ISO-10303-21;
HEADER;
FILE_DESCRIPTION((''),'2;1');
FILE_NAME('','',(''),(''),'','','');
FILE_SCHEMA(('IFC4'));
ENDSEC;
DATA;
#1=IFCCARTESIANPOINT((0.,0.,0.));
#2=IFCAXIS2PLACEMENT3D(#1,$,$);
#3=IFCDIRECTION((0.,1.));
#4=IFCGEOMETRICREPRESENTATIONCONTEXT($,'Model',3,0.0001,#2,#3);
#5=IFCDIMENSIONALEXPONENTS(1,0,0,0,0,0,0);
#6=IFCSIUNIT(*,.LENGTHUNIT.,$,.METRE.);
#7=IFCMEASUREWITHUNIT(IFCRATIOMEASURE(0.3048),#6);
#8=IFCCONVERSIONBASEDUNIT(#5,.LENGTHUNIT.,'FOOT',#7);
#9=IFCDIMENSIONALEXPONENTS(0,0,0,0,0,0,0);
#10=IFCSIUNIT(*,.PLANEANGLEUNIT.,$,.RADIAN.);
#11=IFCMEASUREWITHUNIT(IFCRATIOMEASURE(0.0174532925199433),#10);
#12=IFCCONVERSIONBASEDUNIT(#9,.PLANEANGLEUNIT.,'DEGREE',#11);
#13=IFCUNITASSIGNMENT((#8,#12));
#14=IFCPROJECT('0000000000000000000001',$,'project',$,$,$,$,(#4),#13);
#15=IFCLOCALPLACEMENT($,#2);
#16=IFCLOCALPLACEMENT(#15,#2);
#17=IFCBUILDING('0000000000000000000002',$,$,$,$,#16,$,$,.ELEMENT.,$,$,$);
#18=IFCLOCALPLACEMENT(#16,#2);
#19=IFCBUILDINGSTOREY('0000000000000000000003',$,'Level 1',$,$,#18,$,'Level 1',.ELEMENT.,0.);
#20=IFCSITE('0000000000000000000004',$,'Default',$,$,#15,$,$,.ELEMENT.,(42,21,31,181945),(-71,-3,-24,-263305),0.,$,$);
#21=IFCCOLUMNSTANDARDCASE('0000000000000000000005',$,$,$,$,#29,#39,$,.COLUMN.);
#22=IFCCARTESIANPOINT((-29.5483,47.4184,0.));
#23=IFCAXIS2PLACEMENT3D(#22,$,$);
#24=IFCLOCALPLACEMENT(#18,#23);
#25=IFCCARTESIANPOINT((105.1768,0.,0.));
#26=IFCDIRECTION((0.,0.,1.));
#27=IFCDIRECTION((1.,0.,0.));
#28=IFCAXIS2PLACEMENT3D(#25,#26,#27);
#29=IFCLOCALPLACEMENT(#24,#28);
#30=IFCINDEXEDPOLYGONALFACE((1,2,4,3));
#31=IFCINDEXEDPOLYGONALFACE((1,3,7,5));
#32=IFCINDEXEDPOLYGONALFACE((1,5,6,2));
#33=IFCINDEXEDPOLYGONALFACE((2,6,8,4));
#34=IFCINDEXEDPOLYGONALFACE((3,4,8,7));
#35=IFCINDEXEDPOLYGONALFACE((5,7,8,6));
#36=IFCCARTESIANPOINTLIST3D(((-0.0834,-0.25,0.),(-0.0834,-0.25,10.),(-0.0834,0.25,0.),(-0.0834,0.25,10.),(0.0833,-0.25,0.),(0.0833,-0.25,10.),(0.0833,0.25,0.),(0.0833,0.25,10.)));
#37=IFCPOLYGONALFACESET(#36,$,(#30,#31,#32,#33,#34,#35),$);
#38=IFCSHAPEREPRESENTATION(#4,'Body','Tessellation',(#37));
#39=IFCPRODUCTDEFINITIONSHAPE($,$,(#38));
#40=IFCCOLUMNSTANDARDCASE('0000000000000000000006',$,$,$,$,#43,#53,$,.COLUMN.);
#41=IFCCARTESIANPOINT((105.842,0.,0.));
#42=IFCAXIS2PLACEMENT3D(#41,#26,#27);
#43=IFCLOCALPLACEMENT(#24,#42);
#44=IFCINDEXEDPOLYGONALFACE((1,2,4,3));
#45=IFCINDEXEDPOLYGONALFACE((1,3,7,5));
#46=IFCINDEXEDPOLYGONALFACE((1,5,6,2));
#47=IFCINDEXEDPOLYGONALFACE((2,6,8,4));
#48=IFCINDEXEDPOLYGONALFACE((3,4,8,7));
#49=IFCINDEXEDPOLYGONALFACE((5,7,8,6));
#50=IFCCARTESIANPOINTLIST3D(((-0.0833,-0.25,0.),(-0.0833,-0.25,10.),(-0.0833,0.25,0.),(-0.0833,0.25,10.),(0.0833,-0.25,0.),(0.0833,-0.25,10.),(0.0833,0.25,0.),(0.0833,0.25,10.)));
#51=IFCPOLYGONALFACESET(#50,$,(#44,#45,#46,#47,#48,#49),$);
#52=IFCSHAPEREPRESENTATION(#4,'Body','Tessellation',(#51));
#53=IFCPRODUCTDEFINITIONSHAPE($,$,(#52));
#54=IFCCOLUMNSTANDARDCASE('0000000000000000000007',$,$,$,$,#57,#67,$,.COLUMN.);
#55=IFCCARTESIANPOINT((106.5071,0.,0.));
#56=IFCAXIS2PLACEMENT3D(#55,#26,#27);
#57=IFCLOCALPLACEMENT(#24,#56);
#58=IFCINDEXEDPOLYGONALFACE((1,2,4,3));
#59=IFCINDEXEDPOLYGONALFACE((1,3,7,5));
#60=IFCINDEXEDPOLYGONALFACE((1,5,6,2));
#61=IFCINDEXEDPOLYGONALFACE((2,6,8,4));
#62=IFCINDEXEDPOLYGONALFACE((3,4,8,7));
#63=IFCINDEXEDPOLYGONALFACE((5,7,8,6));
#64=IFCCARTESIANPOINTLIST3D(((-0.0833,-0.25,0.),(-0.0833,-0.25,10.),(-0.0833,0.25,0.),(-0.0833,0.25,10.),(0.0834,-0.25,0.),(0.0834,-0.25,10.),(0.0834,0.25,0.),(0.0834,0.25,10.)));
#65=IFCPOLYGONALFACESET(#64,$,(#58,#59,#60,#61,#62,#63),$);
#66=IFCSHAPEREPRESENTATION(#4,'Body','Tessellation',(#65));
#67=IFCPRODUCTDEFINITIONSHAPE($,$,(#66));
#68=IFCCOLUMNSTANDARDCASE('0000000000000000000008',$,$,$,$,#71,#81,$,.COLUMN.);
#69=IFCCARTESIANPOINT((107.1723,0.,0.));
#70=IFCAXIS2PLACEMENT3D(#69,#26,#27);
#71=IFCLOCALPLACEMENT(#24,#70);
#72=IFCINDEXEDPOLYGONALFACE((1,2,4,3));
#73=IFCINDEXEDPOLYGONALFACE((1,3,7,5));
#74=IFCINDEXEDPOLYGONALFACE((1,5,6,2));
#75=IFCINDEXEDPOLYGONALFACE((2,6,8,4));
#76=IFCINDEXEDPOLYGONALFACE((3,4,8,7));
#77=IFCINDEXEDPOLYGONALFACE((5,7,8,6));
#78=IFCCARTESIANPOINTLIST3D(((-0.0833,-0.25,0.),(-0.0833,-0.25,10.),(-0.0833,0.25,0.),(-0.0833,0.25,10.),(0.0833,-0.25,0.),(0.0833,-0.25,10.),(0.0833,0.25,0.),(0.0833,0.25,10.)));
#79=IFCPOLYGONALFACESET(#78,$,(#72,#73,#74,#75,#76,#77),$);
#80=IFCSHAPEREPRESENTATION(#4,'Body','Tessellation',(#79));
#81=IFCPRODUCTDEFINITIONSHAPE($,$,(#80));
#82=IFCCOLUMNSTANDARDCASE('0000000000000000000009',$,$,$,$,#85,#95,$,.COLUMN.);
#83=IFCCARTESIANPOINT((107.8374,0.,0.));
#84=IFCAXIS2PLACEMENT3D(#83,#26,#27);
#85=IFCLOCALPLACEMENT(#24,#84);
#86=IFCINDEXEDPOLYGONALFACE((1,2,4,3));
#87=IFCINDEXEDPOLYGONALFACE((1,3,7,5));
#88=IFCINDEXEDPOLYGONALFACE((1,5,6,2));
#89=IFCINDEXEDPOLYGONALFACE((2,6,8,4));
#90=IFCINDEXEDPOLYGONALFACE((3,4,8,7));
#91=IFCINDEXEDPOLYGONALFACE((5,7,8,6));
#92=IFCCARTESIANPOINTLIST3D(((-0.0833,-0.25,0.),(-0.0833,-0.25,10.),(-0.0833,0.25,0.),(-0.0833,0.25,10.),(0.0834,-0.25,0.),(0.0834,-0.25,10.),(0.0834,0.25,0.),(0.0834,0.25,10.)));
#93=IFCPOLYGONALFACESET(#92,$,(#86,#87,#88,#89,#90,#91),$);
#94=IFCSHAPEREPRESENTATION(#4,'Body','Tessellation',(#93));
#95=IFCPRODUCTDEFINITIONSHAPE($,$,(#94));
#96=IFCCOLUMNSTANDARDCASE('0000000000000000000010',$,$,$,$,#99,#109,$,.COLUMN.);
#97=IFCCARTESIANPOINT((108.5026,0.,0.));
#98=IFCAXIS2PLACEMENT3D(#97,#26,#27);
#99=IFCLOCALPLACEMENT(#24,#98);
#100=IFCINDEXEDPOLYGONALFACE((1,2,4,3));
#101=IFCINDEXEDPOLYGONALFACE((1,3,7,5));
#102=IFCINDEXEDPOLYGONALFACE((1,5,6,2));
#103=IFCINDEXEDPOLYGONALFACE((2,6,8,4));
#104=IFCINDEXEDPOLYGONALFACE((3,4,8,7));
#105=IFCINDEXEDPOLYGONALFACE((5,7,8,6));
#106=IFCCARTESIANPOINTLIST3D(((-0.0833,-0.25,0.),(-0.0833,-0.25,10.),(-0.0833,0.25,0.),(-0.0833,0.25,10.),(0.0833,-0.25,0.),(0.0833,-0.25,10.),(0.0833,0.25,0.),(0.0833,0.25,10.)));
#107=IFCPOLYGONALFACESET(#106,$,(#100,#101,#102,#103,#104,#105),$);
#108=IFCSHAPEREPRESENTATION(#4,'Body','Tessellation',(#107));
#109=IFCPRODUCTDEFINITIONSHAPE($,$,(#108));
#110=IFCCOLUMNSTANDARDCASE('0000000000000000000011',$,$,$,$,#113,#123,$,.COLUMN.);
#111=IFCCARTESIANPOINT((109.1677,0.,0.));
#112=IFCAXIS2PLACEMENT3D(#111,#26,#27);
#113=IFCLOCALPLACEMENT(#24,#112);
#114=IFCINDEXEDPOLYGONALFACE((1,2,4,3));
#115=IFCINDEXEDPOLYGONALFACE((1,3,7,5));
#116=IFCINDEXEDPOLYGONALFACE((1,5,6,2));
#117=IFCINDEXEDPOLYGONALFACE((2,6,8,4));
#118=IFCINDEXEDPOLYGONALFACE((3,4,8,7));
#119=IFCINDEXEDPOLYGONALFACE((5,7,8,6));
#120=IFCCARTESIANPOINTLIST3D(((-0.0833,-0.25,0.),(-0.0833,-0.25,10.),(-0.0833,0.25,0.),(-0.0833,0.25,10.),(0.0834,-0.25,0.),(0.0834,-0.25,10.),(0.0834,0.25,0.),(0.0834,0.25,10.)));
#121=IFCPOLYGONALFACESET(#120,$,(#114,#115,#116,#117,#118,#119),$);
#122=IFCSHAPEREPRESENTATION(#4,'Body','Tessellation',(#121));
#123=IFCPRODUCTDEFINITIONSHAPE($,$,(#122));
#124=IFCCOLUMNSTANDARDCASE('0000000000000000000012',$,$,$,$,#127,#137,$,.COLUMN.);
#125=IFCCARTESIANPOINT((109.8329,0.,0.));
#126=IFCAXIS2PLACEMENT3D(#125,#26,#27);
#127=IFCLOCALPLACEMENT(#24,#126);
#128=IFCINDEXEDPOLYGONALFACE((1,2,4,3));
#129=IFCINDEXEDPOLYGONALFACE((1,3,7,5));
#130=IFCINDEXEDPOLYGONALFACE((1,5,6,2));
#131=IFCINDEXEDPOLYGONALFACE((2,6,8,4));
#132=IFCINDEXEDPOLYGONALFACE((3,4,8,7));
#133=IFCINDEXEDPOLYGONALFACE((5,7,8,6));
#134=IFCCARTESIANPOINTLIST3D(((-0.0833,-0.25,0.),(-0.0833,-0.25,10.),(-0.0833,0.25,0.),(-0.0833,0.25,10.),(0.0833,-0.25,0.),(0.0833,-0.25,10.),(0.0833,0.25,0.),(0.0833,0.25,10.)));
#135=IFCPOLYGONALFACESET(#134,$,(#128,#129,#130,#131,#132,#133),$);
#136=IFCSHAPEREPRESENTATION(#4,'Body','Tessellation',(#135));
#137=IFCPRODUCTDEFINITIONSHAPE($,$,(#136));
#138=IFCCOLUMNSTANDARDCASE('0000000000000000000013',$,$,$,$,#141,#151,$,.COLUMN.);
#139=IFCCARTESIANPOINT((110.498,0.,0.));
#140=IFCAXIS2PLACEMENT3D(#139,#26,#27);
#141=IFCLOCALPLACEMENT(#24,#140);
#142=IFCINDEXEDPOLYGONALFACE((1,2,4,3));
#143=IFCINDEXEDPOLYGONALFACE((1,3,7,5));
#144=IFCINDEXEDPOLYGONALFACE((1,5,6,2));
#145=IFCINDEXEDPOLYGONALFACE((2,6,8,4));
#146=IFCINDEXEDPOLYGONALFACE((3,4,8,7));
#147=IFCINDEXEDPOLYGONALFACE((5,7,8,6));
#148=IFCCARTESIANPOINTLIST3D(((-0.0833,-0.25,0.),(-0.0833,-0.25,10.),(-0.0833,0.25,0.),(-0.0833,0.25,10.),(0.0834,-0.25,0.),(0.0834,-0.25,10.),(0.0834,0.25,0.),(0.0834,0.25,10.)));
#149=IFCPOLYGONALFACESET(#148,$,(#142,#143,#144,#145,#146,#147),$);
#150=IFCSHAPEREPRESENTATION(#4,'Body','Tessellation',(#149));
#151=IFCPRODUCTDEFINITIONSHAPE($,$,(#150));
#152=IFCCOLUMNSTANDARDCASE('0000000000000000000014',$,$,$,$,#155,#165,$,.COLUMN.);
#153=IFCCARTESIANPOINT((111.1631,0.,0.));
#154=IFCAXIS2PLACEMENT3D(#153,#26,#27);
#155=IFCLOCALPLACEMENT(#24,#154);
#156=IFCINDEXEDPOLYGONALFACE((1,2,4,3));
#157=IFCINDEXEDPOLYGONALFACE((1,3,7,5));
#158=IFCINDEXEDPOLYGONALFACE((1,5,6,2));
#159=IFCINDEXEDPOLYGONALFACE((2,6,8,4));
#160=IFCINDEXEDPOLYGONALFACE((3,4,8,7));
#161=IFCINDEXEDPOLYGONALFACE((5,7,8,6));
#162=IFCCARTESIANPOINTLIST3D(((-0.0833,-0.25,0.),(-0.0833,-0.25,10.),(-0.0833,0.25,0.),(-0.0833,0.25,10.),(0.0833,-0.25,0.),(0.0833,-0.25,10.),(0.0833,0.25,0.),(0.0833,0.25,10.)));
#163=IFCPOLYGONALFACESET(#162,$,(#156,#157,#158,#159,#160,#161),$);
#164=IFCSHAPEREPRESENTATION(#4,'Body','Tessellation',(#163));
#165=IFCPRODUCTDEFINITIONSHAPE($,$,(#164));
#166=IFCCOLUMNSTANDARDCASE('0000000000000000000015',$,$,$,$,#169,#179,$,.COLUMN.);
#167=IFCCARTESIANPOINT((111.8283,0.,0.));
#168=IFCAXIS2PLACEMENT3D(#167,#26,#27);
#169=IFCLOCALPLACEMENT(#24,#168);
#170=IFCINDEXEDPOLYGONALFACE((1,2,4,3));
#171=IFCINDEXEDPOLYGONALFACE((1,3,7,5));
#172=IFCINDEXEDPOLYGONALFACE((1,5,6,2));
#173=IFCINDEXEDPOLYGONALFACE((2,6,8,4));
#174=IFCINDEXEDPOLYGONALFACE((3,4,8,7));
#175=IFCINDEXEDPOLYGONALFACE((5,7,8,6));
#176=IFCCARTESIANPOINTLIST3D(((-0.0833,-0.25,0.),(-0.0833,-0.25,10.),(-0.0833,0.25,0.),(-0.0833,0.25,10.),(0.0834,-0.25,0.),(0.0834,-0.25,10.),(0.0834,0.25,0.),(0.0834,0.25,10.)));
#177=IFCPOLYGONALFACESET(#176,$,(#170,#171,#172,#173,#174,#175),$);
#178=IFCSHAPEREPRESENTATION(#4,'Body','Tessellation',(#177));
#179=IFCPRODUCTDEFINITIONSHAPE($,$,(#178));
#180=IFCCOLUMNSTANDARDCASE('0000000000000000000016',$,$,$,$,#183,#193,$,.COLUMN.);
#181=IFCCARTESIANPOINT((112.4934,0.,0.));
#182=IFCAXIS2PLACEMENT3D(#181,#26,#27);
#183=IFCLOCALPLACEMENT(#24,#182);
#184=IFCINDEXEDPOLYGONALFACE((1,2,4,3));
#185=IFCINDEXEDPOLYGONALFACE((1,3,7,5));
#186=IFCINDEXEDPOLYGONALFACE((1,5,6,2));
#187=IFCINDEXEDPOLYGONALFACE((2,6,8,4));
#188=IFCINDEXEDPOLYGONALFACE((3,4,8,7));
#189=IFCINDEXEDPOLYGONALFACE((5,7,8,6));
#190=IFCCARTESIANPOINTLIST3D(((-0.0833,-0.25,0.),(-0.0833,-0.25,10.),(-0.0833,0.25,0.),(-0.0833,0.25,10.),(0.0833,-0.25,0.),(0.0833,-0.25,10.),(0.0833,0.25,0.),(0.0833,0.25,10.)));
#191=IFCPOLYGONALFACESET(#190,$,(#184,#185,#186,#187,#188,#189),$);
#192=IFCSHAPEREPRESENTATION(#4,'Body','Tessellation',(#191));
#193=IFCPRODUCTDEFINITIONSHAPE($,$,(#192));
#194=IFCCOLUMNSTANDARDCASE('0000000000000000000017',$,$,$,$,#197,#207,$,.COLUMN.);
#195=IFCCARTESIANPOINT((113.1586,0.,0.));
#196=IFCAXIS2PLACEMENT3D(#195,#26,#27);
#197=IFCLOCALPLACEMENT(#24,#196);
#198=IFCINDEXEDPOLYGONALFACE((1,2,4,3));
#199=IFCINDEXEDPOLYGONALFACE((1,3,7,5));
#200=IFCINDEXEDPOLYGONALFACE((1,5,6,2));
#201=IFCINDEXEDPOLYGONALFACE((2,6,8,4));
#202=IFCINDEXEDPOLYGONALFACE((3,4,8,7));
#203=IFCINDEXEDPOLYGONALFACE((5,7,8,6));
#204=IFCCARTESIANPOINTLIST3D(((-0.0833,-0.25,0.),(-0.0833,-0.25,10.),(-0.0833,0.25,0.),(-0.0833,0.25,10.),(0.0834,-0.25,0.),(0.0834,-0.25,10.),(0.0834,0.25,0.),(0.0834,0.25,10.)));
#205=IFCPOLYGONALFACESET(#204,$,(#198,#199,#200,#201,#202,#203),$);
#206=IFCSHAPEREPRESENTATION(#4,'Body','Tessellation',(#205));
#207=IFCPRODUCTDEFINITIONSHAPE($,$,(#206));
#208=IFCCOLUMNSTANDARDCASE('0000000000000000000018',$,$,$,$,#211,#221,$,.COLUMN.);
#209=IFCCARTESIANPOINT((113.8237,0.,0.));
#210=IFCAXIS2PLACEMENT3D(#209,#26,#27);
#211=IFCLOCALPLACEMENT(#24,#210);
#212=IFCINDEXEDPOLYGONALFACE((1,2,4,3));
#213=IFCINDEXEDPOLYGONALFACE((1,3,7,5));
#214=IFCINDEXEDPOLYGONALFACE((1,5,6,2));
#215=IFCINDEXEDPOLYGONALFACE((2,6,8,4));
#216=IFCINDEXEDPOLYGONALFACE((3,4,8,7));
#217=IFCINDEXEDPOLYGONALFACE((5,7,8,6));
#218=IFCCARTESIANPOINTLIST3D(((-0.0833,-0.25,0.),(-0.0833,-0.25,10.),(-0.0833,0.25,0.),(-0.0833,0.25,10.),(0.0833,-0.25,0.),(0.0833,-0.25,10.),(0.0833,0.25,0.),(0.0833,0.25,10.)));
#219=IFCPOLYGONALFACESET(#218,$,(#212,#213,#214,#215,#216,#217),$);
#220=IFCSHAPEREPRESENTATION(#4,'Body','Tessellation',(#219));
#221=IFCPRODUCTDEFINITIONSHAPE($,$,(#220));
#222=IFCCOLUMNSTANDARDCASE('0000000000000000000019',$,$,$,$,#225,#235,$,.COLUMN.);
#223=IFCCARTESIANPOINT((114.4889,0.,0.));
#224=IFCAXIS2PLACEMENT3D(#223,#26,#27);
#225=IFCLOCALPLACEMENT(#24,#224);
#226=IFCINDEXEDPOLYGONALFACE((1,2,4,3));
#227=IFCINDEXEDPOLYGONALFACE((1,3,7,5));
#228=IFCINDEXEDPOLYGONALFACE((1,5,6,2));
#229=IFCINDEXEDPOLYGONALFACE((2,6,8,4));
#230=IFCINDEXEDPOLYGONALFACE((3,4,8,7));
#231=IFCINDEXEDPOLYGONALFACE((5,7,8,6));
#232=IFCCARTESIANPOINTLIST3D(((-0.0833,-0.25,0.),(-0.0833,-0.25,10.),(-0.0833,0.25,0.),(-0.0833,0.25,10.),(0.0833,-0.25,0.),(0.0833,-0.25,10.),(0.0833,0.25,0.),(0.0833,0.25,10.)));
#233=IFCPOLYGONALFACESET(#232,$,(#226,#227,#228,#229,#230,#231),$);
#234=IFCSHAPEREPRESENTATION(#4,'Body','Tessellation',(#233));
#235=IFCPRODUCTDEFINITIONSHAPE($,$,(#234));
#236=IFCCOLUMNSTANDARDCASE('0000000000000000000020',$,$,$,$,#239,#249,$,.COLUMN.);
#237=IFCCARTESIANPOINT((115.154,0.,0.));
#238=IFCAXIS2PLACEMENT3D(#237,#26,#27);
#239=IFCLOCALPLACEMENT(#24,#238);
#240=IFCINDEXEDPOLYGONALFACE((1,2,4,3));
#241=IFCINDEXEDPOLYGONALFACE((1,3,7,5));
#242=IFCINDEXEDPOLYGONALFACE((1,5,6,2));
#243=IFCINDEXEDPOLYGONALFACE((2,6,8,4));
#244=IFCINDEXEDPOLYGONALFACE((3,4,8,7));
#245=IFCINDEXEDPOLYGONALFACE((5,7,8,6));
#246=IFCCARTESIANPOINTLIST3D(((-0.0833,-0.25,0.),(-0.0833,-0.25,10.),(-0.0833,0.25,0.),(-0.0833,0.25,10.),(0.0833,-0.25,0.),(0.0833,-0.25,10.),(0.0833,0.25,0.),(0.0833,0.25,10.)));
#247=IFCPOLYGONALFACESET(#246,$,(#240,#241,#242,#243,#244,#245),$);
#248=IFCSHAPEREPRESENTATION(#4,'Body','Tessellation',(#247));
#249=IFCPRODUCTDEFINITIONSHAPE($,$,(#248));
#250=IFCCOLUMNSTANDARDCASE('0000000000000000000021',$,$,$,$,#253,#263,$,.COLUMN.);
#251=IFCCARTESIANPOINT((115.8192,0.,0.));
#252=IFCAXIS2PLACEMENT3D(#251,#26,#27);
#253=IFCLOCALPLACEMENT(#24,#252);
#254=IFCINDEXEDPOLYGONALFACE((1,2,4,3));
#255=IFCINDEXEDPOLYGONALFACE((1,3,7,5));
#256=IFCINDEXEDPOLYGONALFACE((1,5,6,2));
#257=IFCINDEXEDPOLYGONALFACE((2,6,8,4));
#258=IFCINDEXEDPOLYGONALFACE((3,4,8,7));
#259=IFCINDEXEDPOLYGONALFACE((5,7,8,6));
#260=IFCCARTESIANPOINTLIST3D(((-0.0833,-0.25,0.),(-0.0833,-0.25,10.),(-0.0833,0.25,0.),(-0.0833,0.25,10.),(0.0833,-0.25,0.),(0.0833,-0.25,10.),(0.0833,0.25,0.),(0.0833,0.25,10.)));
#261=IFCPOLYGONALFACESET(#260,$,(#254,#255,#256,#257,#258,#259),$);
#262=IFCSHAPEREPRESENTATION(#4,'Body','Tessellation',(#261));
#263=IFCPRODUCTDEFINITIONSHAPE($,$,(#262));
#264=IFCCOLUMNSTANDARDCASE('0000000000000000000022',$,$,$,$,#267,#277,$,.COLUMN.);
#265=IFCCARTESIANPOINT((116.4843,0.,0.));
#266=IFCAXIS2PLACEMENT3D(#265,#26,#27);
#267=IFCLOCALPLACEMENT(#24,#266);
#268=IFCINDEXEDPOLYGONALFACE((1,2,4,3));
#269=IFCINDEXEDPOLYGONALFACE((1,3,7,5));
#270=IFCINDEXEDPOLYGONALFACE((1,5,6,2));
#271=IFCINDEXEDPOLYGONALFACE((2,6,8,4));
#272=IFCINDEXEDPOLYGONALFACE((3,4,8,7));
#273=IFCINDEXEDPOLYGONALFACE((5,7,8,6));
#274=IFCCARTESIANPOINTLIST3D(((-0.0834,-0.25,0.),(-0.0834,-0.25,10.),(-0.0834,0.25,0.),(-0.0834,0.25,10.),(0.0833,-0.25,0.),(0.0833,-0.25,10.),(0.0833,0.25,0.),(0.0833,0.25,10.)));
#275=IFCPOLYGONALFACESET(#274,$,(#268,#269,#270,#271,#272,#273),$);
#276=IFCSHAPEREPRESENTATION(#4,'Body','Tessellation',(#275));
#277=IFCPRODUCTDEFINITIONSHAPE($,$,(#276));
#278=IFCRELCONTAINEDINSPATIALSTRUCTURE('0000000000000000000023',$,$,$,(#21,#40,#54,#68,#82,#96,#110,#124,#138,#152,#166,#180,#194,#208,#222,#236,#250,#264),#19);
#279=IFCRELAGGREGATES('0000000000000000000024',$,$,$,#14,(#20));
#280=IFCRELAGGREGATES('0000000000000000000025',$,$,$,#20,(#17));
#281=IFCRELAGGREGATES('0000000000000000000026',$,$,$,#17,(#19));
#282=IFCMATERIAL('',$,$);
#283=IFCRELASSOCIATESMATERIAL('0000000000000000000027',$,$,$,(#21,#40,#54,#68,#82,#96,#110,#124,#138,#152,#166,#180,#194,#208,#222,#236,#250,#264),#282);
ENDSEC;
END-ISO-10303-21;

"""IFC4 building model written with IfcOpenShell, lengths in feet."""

from ifc_helpers import new_model, entity, si_unit, converted_unit, direction, frame, origin, place, context, project, spatial, rectangle, extrude, material, element, save


model = new_model("IFC4")

# Units and contexts
model_context = context("Model", 3, precision=0.0001, world=origin(), true_north=direction((0.0, 1.0)))
ifc_project = project(units=[converted_unit("LENGTHUNIT", "FOOT", entity("IfcRatioMeasure", 0.3048), si_unit("LENGTHUNIT", "METRE"), dimensions=[1, 0, 0, 0, 0, 0, 0]), converted_unit("PLANEANGLEUNIT", "DEGREE", entity("IfcRatioMeasure", 0.0174532925199433), si_unit("PLANEANGLEUNIT", "RADIAN"), dimensions=[0, 0, 0, 0, 0, 0, 0])], contexts=[model_context])

# Site, building, storey
site_placement = place(None, origin())
site = spatial("IfcSite", under=ifc_project, at=site_placement, Name="Default", CompositionType="ELEMENT", RefLatitude=(42, 21, 31, 181945), RefLongitude=(-71, -3, -24, -263305), RefElevation=0.0)
building_placement = place(site_placement, origin())
building = spatial("IfcBuilding", under=site, at=building_placement, CompositionType="ELEMENT")
storey_placement = place(building_placement, origin())
storey = spatial("IfcBuildingStorey", under=building, at=storey_placement, Name="Level 1", LongName="Level 1", CompositionType="ELEMENT", Elevation=0.0)

# Columns
ifc_material = material(Name="")
placement = place(storey_placement, frame((-29.5483, 47.4184, 0.0)))
for number, where, z_axis, x_axis in (
    (1, (105.1768, 0.0, 0.0), (0.0, 0.0, 1.0), (1.0, 0.0, 0.0)),
    (2, (105.842, 0.0, 0.0), (0.0, 0.0, 1.0), (1.0, 0.0, 0.0)),
    (3, (106.5071, 0.0, 0.0), (0.0, 0.0, 1.0), (1.0, 0.0, 0.0)),
    (4, (107.1723, 0.0, 0.0), (0.0, 0.0, 1.0), (1.0, 0.0, 0.0)),
    (5, (107.8374, 0.0, 0.0), (0.0, 0.0, 1.0), (1.0, 0.0, 0.0)),
    (6, (108.5026, 0.0, 0.0), (0.0, 0.0, 1.0), (1.0, 0.0, 0.0)),
    (7, (109.1677, 0.0, 0.0), (0.0, 0.0, 1.0), (1.0, 0.0, 0.0)),
    (8, (109.8329, 0.0, 0.0), (0.0, 0.0, 1.0), (1.0, 0.0, 0.0)),
    (9, (110.498, 0.0, 0.0), (0.0, 0.0, 1.0), (1.0, 0.0, 0.0)),
    (10, (111.1631, 0.0, 0.0), (0.0, 0.0, 1.0), (1.0, 0.0, 0.0)),
    (11, (111.8283, 0.0, 0.0), (0.0, 0.0, 1.0), (1.0, 0.0, 0.0)),
    (12, (112.4934, 0.0, 0.0), (0.0, 0.0, 1.0), (1.0, 0.0, 0.0)),
    (13, (113.1586, 0.0, 0.0), (0.0, 0.0, 1.0), (1.0, 0.0, 0.0)),
    (14, (113.8237, 0.0, 0.0), (0.0, 0.0, 1.0), (1.0, 0.0, 0.0)),
    (15, (114.4889, 0.0, 0.0), (0.0, 0.0, 1.0), (1.0, 0.0, 0.0)),
    (16, (115.154, 0.0, 0.0), (0.0, 0.0, 1.0), (1.0, 0.0, 0.0)),
    (17, (115.8192, 0.0, 0.0), (0.0, 0.0, 1.0), (1.0, 0.0, 0.0)),
    (18, (116.4843, 0.0, 0.0), (0.0, 0.0, 1.0), (1.0, 0.0, 0.0)),
):
    element("IfcColumnStandardCase", number, at=place(placement, frame(where, z_axis=z_axis, x_axis=x_axis)), inside=storey, material=ifc_material, PredefinedType="COLUMN", context=model_context, shape_type="SweptSolid", body=[
        extrude(rectangle(XDim=0.1667, YDim=0.5), origin(), (0.0, 0.0, 1.0), 10.0),
    ])

save(model, "model.ifc")
